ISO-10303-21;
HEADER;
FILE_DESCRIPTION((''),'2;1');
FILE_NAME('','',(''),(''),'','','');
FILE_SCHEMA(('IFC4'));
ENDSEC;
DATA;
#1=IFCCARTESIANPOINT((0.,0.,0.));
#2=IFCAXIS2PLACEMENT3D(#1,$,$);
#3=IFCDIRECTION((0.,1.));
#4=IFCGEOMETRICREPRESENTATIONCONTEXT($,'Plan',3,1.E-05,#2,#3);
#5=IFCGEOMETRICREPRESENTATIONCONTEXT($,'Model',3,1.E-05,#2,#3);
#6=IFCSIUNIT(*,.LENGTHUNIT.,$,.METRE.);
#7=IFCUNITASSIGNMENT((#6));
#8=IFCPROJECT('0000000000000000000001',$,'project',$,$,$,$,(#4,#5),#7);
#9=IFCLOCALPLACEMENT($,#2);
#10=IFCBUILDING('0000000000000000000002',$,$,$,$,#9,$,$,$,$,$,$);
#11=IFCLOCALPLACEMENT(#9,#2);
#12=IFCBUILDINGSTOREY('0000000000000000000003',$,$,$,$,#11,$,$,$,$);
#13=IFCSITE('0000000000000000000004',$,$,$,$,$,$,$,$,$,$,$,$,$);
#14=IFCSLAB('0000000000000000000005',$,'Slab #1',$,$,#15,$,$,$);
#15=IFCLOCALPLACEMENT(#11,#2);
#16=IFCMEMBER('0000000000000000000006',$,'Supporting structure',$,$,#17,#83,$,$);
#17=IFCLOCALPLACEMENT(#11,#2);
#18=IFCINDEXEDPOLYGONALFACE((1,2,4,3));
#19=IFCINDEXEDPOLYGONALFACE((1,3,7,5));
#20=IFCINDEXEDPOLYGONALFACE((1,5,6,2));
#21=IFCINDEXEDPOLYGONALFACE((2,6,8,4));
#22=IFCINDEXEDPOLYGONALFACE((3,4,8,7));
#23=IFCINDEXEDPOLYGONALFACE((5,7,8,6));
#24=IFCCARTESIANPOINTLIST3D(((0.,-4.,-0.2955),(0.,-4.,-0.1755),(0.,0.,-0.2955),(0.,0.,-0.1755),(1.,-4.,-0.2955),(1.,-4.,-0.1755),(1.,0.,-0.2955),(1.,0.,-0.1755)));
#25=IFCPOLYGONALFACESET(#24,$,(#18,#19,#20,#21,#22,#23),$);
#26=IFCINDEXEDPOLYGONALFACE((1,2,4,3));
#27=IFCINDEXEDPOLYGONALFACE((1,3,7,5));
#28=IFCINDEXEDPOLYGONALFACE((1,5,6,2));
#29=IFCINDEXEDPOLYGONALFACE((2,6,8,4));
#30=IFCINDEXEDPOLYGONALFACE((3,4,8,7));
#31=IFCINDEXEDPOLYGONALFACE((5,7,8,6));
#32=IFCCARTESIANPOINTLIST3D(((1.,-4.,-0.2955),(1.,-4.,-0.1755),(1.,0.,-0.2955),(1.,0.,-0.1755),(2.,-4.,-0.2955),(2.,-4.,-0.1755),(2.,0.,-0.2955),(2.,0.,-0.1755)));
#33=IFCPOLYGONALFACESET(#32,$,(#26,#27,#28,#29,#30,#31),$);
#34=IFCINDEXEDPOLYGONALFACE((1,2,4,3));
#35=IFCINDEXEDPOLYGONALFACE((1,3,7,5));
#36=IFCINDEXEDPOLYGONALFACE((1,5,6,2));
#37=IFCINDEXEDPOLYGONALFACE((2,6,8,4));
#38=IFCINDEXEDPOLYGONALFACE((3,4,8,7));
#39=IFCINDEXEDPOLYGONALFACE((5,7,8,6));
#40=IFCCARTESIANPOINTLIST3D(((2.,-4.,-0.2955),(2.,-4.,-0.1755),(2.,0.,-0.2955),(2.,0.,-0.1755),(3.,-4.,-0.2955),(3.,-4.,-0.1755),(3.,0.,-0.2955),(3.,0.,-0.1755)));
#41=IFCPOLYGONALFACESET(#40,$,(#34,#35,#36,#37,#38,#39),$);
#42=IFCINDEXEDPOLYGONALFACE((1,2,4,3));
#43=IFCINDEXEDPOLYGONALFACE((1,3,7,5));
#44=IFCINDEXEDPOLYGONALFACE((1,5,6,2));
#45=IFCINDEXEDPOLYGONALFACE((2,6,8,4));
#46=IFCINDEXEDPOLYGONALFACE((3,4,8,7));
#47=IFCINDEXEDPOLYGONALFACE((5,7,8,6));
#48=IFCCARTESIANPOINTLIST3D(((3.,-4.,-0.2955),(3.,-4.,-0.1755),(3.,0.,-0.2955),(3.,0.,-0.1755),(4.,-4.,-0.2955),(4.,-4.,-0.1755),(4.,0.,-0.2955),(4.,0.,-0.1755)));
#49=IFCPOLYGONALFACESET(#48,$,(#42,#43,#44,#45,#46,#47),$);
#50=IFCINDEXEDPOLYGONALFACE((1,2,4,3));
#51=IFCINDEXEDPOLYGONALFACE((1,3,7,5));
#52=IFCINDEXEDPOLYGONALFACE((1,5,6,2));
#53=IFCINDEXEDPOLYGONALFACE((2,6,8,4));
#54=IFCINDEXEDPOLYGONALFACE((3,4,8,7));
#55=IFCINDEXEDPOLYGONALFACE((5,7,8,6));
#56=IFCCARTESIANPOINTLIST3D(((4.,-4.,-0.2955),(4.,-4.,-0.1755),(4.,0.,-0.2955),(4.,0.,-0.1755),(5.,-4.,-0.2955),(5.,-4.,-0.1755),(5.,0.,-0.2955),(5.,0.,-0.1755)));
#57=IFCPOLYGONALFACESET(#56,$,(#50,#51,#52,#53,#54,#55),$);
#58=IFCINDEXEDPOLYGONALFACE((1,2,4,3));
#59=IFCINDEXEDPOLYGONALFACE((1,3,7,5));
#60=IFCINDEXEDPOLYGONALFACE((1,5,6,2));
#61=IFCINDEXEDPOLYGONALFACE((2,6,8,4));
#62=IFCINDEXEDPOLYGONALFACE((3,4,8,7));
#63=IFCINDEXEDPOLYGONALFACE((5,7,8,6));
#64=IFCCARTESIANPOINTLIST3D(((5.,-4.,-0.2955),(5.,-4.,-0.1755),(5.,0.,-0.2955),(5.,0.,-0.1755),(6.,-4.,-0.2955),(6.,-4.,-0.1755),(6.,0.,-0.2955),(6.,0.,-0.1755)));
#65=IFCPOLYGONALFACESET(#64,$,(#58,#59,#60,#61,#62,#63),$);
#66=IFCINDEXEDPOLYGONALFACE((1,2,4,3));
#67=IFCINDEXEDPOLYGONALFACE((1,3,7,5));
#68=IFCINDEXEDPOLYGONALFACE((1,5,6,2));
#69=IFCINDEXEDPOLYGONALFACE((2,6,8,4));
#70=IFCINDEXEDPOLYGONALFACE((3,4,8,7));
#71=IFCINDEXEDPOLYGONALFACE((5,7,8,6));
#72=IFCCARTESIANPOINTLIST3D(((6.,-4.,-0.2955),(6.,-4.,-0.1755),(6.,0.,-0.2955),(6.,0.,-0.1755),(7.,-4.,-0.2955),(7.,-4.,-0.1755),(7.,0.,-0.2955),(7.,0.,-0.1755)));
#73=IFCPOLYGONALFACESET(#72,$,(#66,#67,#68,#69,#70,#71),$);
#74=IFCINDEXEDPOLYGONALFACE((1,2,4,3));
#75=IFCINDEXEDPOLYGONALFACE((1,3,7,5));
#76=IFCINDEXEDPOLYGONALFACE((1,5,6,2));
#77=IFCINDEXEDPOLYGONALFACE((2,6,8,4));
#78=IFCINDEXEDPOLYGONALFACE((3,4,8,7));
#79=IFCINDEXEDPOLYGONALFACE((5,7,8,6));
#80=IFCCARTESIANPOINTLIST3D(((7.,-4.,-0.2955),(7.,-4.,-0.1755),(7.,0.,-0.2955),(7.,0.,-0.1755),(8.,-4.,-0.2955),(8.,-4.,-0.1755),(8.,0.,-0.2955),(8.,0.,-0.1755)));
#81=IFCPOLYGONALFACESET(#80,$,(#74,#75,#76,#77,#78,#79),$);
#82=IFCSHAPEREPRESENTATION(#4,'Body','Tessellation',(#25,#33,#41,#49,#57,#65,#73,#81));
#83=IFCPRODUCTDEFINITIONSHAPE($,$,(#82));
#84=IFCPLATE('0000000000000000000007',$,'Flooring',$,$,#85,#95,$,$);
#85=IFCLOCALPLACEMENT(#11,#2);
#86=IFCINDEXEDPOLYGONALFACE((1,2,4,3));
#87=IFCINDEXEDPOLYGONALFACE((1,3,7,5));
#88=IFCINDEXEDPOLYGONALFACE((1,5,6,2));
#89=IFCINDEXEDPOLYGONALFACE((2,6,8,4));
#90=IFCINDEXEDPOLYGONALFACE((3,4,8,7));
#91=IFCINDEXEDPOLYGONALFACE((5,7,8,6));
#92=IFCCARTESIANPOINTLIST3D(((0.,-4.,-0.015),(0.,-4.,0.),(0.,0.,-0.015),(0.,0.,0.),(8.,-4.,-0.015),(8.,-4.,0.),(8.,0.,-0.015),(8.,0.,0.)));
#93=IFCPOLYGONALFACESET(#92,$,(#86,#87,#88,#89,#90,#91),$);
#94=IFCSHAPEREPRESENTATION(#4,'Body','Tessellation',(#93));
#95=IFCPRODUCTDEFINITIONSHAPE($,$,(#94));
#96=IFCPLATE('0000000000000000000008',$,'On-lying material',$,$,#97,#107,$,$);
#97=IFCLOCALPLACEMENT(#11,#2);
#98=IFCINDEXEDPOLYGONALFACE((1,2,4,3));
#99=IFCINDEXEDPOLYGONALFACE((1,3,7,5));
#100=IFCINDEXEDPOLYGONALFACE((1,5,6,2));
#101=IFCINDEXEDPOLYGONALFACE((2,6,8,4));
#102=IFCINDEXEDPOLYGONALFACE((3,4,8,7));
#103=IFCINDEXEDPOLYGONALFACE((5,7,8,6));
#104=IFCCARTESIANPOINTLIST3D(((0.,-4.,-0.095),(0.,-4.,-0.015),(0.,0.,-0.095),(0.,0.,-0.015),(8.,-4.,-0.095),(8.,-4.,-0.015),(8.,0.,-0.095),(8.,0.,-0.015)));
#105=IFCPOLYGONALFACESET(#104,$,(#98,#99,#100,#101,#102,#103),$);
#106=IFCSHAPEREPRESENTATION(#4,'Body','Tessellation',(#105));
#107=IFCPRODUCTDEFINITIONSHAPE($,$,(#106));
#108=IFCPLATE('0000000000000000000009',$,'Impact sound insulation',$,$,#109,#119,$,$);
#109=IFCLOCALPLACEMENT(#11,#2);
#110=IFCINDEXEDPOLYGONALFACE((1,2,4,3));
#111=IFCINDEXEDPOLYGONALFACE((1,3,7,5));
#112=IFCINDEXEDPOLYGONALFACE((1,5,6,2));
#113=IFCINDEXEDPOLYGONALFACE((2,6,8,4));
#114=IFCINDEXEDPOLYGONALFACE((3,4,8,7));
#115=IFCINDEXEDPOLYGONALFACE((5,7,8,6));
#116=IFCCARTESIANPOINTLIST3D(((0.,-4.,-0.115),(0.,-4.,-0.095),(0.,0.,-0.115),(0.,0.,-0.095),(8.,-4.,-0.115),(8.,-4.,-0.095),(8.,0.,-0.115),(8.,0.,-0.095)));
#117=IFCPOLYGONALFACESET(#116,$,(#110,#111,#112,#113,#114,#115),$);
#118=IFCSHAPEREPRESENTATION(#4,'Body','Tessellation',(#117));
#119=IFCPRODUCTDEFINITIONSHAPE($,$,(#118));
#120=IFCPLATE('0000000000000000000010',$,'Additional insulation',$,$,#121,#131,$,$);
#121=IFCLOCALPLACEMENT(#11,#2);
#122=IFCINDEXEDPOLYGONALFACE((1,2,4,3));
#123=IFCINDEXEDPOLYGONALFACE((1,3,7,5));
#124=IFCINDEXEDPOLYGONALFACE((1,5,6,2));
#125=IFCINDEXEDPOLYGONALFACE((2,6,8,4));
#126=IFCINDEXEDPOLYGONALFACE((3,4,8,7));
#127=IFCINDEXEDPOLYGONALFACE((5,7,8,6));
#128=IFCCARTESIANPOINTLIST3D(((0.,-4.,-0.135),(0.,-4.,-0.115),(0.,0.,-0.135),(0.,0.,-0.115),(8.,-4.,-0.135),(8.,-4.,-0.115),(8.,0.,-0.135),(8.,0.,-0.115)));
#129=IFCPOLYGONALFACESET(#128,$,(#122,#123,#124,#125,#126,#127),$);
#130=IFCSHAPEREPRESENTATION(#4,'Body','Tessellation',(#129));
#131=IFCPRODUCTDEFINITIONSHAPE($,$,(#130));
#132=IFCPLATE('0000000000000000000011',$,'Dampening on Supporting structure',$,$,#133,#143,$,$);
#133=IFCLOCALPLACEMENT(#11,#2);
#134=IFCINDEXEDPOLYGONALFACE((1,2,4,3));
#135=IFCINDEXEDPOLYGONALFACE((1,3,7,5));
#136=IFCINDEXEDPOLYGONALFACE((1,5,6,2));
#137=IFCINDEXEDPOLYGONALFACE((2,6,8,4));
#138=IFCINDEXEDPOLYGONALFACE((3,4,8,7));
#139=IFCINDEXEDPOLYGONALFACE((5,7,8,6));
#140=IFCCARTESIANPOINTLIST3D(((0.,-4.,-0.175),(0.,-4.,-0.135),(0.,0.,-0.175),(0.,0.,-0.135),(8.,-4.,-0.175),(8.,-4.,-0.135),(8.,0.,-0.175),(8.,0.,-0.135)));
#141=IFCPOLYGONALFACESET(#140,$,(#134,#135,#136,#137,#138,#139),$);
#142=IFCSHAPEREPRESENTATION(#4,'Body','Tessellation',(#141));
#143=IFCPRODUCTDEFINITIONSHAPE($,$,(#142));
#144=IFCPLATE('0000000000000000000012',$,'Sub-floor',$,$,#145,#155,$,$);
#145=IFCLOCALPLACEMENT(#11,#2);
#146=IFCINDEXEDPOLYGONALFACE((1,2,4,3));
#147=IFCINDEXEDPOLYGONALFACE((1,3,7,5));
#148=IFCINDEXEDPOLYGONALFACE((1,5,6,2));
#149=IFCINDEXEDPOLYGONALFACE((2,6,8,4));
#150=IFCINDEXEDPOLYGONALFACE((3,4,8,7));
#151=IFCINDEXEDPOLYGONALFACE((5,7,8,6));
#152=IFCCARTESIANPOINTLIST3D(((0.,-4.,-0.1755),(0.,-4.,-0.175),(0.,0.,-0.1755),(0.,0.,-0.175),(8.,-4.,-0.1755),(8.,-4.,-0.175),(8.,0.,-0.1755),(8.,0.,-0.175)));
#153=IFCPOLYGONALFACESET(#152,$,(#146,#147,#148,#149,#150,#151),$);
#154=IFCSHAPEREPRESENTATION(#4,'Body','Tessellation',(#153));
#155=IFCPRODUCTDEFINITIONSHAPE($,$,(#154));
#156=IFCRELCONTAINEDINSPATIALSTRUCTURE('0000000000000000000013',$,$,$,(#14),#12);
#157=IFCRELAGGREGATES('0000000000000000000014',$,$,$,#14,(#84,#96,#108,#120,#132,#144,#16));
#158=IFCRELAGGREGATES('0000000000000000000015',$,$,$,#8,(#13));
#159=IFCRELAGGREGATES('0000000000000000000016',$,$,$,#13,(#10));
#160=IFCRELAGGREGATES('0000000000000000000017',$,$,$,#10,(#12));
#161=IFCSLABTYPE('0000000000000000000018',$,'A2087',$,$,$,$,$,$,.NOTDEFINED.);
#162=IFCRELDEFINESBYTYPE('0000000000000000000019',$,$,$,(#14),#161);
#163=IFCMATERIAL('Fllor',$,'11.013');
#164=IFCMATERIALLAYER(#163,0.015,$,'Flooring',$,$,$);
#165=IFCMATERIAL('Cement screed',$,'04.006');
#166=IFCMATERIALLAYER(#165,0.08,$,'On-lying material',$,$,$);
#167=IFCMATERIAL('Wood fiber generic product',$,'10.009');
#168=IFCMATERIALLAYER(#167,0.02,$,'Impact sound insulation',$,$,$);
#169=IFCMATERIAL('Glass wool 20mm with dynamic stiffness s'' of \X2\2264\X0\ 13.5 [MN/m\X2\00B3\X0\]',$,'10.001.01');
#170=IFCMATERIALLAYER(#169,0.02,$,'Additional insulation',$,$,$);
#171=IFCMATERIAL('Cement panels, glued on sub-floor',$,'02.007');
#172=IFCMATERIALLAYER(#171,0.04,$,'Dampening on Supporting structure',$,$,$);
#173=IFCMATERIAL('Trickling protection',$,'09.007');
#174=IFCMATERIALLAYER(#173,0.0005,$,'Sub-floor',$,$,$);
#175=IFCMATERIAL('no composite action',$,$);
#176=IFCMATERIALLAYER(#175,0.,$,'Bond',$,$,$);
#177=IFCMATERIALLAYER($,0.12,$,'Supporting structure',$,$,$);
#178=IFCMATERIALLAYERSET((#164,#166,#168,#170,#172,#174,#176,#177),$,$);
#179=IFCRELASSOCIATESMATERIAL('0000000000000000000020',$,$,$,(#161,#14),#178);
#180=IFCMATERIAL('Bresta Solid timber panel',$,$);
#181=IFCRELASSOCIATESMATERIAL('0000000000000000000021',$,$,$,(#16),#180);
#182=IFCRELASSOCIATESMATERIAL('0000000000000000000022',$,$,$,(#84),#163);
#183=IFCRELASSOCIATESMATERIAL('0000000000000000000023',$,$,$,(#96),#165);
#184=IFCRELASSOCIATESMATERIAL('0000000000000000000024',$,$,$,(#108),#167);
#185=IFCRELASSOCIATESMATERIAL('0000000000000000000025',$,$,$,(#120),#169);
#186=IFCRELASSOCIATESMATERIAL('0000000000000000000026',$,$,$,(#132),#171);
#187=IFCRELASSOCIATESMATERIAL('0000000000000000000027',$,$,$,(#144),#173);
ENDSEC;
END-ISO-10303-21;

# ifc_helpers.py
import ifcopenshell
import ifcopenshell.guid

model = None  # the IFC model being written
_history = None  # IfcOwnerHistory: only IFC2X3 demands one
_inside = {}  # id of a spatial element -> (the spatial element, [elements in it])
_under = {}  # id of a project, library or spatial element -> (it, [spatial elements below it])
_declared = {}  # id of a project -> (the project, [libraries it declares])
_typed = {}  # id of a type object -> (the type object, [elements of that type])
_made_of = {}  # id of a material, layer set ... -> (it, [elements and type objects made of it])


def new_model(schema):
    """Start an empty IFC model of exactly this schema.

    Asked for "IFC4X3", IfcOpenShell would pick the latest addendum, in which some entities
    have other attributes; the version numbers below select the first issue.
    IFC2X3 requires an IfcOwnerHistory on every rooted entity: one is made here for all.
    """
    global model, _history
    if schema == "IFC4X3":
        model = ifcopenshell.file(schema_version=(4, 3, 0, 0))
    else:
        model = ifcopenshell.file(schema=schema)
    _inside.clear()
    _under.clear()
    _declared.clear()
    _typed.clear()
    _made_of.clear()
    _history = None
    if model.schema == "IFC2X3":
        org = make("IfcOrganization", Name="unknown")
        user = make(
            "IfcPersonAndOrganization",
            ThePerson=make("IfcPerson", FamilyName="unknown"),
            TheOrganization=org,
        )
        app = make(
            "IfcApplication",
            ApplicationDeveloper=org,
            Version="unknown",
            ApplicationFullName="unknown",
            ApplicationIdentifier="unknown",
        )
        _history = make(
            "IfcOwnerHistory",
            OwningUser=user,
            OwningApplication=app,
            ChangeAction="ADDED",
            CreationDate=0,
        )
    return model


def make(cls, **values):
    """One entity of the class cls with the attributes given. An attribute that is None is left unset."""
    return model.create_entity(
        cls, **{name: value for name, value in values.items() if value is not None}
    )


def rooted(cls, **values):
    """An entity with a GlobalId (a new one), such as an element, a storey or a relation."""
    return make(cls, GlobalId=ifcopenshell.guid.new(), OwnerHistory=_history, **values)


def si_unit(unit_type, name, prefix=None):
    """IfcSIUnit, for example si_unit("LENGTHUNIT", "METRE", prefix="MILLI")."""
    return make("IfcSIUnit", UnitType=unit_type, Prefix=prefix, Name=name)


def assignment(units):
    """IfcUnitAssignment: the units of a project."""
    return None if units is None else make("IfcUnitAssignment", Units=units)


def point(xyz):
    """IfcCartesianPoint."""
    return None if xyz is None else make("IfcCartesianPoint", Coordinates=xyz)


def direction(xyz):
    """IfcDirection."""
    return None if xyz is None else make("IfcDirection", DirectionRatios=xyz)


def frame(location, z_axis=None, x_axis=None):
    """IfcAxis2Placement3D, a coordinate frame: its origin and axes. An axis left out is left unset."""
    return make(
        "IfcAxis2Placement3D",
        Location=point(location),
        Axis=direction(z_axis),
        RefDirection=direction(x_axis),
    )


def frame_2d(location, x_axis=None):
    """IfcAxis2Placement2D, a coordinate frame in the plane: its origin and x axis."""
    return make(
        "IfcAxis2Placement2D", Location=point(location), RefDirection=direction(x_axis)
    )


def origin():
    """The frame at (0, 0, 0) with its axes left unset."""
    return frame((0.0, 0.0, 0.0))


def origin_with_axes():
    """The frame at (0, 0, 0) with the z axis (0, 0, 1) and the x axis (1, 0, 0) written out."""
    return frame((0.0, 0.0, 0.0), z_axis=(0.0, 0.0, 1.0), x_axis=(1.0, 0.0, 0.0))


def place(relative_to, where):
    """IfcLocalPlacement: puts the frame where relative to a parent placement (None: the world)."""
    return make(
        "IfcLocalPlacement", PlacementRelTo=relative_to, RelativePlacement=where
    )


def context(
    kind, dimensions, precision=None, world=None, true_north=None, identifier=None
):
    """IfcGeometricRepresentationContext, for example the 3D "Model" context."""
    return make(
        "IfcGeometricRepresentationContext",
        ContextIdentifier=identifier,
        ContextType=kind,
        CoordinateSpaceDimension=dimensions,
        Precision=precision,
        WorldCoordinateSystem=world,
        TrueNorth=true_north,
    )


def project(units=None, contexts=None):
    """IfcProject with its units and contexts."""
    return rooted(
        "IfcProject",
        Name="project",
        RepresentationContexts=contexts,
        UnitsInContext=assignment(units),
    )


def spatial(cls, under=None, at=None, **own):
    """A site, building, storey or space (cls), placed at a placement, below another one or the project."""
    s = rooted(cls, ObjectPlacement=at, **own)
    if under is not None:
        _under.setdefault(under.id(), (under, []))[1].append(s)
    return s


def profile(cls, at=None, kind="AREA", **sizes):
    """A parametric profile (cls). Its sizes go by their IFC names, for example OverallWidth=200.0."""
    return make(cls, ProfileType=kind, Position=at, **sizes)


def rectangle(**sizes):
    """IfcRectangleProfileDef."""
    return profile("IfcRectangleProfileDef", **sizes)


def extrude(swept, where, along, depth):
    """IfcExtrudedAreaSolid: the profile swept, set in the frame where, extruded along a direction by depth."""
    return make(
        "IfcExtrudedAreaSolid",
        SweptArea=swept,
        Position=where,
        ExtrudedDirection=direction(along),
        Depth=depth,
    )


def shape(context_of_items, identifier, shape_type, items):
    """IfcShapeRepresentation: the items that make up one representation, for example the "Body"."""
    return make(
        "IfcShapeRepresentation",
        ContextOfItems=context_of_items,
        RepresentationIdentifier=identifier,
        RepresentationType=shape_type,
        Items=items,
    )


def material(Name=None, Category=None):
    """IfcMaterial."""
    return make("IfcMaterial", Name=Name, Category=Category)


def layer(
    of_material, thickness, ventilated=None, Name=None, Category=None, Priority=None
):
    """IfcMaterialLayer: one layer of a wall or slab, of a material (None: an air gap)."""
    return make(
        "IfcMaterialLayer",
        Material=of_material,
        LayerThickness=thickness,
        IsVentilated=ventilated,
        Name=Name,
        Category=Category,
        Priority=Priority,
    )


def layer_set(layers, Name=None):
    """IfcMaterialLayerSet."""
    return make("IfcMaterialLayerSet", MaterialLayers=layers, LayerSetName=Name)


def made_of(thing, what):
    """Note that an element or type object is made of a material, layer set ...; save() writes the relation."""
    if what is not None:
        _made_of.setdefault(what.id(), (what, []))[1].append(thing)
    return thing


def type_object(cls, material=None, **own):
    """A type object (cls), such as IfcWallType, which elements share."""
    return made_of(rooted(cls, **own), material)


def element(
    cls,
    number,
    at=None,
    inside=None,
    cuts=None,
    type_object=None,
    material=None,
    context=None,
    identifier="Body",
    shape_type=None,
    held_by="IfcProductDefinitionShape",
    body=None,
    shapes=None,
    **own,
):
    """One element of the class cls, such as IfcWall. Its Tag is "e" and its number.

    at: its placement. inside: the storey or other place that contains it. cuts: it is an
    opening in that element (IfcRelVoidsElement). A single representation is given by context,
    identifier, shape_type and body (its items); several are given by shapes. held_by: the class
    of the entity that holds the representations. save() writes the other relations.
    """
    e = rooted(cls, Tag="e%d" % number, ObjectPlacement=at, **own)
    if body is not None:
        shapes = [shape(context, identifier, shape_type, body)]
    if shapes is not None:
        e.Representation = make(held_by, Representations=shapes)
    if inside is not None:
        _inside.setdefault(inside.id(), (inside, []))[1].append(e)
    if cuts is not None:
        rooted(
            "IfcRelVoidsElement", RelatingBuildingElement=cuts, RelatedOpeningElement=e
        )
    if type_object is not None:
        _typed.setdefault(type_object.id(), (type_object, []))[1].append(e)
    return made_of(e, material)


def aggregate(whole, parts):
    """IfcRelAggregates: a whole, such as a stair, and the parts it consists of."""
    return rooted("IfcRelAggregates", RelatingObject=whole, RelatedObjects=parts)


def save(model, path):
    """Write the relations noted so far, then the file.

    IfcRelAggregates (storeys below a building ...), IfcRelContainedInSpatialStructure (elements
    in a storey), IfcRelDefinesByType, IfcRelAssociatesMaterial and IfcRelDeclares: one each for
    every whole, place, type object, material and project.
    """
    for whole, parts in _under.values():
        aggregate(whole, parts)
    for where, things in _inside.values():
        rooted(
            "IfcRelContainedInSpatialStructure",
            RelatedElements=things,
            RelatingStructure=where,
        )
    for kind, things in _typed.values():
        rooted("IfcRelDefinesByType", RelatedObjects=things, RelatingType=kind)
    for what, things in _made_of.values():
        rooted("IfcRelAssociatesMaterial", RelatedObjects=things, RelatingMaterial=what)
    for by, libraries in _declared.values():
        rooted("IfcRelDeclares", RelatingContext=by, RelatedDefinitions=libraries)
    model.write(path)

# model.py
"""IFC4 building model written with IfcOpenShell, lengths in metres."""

from ifc_helpers import new_model, si_unit, direction, frame, frame_2d, origin, origin_with_axes, place, context, project, spatial, rectangle, extrude, material, layer, layer_set, type_object, element, aggregate, save


model = new_model("IFC4")

# Units and contexts
plan_context = context("Plan", 3, precision=1e-05, world=origin(), true_north=direction((0.0, 1.0)))
model_context = context("Model", 3, precision=1e-05, world=origin(), true_north=direction((0.0, 1.0)))
ifc_project = project(units=[si_unit("LENGTHUNIT", "METRE")], contexts=[plan_context, model_context])

# Site, building, storey
site = spatial("IfcSite", under=ifc_project)
building_placement = place(None, origin())
building = spatial("IfcBuilding", under=site, at=building_placement)
storey_placement = place(building_placement, origin())
storey = spatial("IfcBuildingStorey", under=building, at=storey_placement)

# Slab, member, plates
ifc_material_1 = material(Name="Fllor", Category="11.013")
ifc_layer_1 = layer(ifc_material_1, 0.015, Name="Flooring")
ifc_material_2 = material(Name="Cement screed", Category="04.006")
ifc_layer_2 = layer(ifc_material_2, 0.08, Name="On-lying material")
ifc_material_3 = material(Name="Wood fiber generic product", Category="10.009")
ifc_layer_3 = layer(ifc_material_3, 0.02, Name="Impact sound insulation")
ifc_material_4 = material(Name="Glass wool 20mm with dynamic stiffness s' of ≤ 13.5 [MN/m³]", Category="10.001.01")
ifc_layer_4 = layer(ifc_material_4, 0.02, Name="Additional insulation")
ifc_material_5 = material(Name="Cement panels, glued on sub-floor", Category="02.007")
ifc_layer_5 = layer(ifc_material_5, 0.04, Name="Dampening on Supporting structure")
ifc_material_6 = material(Name="Trickling protection", Category="09.007")
ifc_layer_6 = layer(ifc_material_6, 0.0005, Name="Sub-floor")
ifc_material_7 = material(Name="no composite action")
ifc_layer_7 = layer(ifc_material_7, 0.0, Name="Bond")
ifc_layer_8 = layer(None, 0.12, Name="Supporting structure")
ifc_layer_set = layer_set([ifc_layer_1, ifc_layer_2, ifc_layer_3, ifc_layer_4, ifc_layer_5, ifc_layer_6, ifc_layer_7, ifc_layer_8])
slab_type = type_object("IfcSlabType", Name="A2087", PredefinedType="NOTDEFINED", material=ifc_layer_set)
slab_placement = place(None, frame((0.0, 0.0, 0.0), z_axis=(0.0, 0.0, -1.0), x_axis=(1.0, 0.0, 0.0)))
slab = element("IfcSlab", 1, at=slab_placement, inside=storey, type_object=slab_type, material=ifc_layer_set, Name="Slab #1")
ifc_material_8 = material(Name="Bresta Solid timber panel")
member_placement = place(slab_placement, origin())
member = element("IfcMember", 2, at=member_placement, material=ifc_material_8, Name="Supporting structure", context=plan_context, shape_type="SweptSolid", body=[
    extrude(rectangle(XDim=1.0, YDim=0.12, at=frame_2d((0.5, 0.06), x_axis=(1.0, 0.0))), frame((0.0, 4.0, 0.1755), z_axis=(0.0, -1.0, 0.0), x_axis=(1.0, 0.0, 0.0)), (0.0, 0.0, 1.0), 4.0),
    extrude(rectangle(XDim=1.0, YDim=0.12, at=frame_2d((0.5, 0.06), x_axis=(1.0, 0.0))), frame((1.0, 4.0, 0.1755), z_axis=(0.0, -1.0, 0.0), x_axis=(1.0, 0.0, 0.0)), (0.0, 0.0, 1.0), 4.0),
    extrude(rectangle(XDim=1.0, YDim=0.12, at=frame_2d((0.5, 0.06), x_axis=(1.0, 0.0))), frame((2.0, 4.0, 0.1755), z_axis=(0.0, -1.0, 0.0), x_axis=(1.0, 0.0, 0.0)), (0.0, 0.0, 1.0), 4.0),
    extrude(rectangle(XDim=1.0, YDim=0.12, at=frame_2d((0.5, 0.06), x_axis=(1.0, 0.0))), frame((3.0, 4.0, 0.1755), z_axis=(0.0, -1.0, 0.0), x_axis=(1.0, 0.0, 0.0)), (0.0, 0.0, 1.0), 4.0),
    extrude(rectangle(XDim=1.0, YDim=0.12, at=frame_2d((0.5, 0.06), x_axis=(1.0, 0.0))), frame((4.0, 4.0, 0.1755), z_axis=(0.0, -1.0, 0.0), x_axis=(1.0, 0.0, 0.0)), (0.0, 0.0, 1.0), 4.0),
    extrude(rectangle(XDim=1.0, YDim=0.12, at=frame_2d((0.5, 0.06), x_axis=(1.0, 0.0))), frame((5.0, 4.0, 0.1755), z_axis=(0.0, -1.0, 0.0), x_axis=(1.0, 0.0, 0.0)), (0.0, 0.0, 1.0), 4.0),
    extrude(rectangle(XDim=1.0, YDim=0.12, at=frame_2d((0.5, 0.06), x_axis=(1.0, 0.0))), frame((6.0, 4.0, 0.1755), z_axis=(0.0, -1.0, 0.0), x_axis=(1.0, 0.0, 0.0)), (0.0, 0.0, 1.0), 4.0),
    extrude(rectangle(XDim=1.0, YDim=0.12, at=frame_2d((0.5, 0.06), x_axis=(1.0, 0.0))), frame((7.0, 4.0, 0.1755), z_axis=(0.0, -1.0, 0.0), x_axis=(1.0, 0.0, 0.0)), (0.0, 0.0, 1.0), 4.0),
])
plate_1_placement = place(slab_placement, origin())
plate_1 = element("IfcPlate", 3, at=plate_1_placement, material=ifc_material_1, Name="Flooring", context=plan_context, shape_type="SweptSolid", body=[
    extrude(rectangle(XDim=8.0, YDim=4.0, at=frame_2d((4.0, 2.0), x_axis=(1.0, 0.0))), origin_with_axes(), (0.0, 0.0, 1.0), 0.015),
])
plate_2_placement = place(slab_placement, origin())
plate_2 = element("IfcPlate", 4, at=plate_2_placement, material=ifc_material_2, Name="On-lying material", context=plan_context, shape_type="SweptSolid", body=[
    extrude(rectangle(XDim=8.0, YDim=4.0, at=frame_2d((4.0, 2.0), x_axis=(1.0, 0.0))), frame((0.0, 0.0, 0.015), z_axis=(0.0, 0.0, 1.0), x_axis=(1.0, 0.0, 0.0)), (0.0, 0.0, 1.0), 0.08),
])
plate_3_placement = place(slab_placement, origin())
plate_3 = element("IfcPlate", 5, at=plate_3_placement, material=ifc_material_3, Name="Impact sound insulation", context=plan_context, shape_type="SweptSolid", body=[
    extrude(rectangle(XDim=8.0, YDim=4.0, at=frame_2d((4.0, 2.0), x_axis=(1.0, 0.0))), frame((0.0, 0.0, 0.095), z_axis=(0.0, 0.0, 1.0), x_axis=(1.0, 0.0, 0.0)), (0.0, 0.0, 1.0), 0.02),
])
plate_4_placement = place(slab_placement, origin())
plate_4 = element("IfcPlate", 6, at=plate_4_placement, material=ifc_material_4, Name="Additional insulation", context=plan_context, shape_type="SweptSolid", body=[
    extrude(rectangle(XDim=8.0, YDim=4.0, at=frame_2d((4.0, 2.0), x_axis=(1.0, 0.0))), frame((0.0, 0.0, 0.115), z_axis=(0.0, 0.0, 1.0), x_axis=(1.0, 0.0, 0.0)), (0.0, 0.0, 1.0), 0.02),
])
plate_5_placement = place(slab_placement, origin())
plate_5 = element("IfcPlate", 7, at=plate_5_placement, material=ifc_material_5, Name="Dampening on Supporting structure", context=plan_context, shape_type="SweptSolid", body=[
    extrude(rectangle(XDim=8.0, YDim=4.0, at=frame_2d((4.0, 2.0), x_axis=(1.0, 0.0))), frame((0.0, 0.0, 0.135), z_axis=(0.0, 0.0, 1.0), x_axis=(1.0, 0.0, 0.0)), (0.0, 0.0, 1.0), 0.04),
])
plate_6_placement = place(slab_placement, origin())
plate_6 = element("IfcPlate", 8, at=plate_6_placement, material=ifc_material_6, Name="Sub-floor", context=plan_context, shape_type="SweptSolid", body=[
    extrude(rectangle(XDim=8.0, YDim=4.0, at=frame_2d((4.0, 2.0), x_axis=(1.0, 0.0))), frame((0.0, 0.0, 0.175), z_axis=(0.0, 0.0, 1.0), x_axis=(1.0, 0.0, 0.0)), (0.0, 0.0, 1.0), 0.0005),
])
aggregate(slab, [plate_1, plate_2, plate_3, plate_4, plate_5, plate_6, member])

save(model, "model.ifc")
